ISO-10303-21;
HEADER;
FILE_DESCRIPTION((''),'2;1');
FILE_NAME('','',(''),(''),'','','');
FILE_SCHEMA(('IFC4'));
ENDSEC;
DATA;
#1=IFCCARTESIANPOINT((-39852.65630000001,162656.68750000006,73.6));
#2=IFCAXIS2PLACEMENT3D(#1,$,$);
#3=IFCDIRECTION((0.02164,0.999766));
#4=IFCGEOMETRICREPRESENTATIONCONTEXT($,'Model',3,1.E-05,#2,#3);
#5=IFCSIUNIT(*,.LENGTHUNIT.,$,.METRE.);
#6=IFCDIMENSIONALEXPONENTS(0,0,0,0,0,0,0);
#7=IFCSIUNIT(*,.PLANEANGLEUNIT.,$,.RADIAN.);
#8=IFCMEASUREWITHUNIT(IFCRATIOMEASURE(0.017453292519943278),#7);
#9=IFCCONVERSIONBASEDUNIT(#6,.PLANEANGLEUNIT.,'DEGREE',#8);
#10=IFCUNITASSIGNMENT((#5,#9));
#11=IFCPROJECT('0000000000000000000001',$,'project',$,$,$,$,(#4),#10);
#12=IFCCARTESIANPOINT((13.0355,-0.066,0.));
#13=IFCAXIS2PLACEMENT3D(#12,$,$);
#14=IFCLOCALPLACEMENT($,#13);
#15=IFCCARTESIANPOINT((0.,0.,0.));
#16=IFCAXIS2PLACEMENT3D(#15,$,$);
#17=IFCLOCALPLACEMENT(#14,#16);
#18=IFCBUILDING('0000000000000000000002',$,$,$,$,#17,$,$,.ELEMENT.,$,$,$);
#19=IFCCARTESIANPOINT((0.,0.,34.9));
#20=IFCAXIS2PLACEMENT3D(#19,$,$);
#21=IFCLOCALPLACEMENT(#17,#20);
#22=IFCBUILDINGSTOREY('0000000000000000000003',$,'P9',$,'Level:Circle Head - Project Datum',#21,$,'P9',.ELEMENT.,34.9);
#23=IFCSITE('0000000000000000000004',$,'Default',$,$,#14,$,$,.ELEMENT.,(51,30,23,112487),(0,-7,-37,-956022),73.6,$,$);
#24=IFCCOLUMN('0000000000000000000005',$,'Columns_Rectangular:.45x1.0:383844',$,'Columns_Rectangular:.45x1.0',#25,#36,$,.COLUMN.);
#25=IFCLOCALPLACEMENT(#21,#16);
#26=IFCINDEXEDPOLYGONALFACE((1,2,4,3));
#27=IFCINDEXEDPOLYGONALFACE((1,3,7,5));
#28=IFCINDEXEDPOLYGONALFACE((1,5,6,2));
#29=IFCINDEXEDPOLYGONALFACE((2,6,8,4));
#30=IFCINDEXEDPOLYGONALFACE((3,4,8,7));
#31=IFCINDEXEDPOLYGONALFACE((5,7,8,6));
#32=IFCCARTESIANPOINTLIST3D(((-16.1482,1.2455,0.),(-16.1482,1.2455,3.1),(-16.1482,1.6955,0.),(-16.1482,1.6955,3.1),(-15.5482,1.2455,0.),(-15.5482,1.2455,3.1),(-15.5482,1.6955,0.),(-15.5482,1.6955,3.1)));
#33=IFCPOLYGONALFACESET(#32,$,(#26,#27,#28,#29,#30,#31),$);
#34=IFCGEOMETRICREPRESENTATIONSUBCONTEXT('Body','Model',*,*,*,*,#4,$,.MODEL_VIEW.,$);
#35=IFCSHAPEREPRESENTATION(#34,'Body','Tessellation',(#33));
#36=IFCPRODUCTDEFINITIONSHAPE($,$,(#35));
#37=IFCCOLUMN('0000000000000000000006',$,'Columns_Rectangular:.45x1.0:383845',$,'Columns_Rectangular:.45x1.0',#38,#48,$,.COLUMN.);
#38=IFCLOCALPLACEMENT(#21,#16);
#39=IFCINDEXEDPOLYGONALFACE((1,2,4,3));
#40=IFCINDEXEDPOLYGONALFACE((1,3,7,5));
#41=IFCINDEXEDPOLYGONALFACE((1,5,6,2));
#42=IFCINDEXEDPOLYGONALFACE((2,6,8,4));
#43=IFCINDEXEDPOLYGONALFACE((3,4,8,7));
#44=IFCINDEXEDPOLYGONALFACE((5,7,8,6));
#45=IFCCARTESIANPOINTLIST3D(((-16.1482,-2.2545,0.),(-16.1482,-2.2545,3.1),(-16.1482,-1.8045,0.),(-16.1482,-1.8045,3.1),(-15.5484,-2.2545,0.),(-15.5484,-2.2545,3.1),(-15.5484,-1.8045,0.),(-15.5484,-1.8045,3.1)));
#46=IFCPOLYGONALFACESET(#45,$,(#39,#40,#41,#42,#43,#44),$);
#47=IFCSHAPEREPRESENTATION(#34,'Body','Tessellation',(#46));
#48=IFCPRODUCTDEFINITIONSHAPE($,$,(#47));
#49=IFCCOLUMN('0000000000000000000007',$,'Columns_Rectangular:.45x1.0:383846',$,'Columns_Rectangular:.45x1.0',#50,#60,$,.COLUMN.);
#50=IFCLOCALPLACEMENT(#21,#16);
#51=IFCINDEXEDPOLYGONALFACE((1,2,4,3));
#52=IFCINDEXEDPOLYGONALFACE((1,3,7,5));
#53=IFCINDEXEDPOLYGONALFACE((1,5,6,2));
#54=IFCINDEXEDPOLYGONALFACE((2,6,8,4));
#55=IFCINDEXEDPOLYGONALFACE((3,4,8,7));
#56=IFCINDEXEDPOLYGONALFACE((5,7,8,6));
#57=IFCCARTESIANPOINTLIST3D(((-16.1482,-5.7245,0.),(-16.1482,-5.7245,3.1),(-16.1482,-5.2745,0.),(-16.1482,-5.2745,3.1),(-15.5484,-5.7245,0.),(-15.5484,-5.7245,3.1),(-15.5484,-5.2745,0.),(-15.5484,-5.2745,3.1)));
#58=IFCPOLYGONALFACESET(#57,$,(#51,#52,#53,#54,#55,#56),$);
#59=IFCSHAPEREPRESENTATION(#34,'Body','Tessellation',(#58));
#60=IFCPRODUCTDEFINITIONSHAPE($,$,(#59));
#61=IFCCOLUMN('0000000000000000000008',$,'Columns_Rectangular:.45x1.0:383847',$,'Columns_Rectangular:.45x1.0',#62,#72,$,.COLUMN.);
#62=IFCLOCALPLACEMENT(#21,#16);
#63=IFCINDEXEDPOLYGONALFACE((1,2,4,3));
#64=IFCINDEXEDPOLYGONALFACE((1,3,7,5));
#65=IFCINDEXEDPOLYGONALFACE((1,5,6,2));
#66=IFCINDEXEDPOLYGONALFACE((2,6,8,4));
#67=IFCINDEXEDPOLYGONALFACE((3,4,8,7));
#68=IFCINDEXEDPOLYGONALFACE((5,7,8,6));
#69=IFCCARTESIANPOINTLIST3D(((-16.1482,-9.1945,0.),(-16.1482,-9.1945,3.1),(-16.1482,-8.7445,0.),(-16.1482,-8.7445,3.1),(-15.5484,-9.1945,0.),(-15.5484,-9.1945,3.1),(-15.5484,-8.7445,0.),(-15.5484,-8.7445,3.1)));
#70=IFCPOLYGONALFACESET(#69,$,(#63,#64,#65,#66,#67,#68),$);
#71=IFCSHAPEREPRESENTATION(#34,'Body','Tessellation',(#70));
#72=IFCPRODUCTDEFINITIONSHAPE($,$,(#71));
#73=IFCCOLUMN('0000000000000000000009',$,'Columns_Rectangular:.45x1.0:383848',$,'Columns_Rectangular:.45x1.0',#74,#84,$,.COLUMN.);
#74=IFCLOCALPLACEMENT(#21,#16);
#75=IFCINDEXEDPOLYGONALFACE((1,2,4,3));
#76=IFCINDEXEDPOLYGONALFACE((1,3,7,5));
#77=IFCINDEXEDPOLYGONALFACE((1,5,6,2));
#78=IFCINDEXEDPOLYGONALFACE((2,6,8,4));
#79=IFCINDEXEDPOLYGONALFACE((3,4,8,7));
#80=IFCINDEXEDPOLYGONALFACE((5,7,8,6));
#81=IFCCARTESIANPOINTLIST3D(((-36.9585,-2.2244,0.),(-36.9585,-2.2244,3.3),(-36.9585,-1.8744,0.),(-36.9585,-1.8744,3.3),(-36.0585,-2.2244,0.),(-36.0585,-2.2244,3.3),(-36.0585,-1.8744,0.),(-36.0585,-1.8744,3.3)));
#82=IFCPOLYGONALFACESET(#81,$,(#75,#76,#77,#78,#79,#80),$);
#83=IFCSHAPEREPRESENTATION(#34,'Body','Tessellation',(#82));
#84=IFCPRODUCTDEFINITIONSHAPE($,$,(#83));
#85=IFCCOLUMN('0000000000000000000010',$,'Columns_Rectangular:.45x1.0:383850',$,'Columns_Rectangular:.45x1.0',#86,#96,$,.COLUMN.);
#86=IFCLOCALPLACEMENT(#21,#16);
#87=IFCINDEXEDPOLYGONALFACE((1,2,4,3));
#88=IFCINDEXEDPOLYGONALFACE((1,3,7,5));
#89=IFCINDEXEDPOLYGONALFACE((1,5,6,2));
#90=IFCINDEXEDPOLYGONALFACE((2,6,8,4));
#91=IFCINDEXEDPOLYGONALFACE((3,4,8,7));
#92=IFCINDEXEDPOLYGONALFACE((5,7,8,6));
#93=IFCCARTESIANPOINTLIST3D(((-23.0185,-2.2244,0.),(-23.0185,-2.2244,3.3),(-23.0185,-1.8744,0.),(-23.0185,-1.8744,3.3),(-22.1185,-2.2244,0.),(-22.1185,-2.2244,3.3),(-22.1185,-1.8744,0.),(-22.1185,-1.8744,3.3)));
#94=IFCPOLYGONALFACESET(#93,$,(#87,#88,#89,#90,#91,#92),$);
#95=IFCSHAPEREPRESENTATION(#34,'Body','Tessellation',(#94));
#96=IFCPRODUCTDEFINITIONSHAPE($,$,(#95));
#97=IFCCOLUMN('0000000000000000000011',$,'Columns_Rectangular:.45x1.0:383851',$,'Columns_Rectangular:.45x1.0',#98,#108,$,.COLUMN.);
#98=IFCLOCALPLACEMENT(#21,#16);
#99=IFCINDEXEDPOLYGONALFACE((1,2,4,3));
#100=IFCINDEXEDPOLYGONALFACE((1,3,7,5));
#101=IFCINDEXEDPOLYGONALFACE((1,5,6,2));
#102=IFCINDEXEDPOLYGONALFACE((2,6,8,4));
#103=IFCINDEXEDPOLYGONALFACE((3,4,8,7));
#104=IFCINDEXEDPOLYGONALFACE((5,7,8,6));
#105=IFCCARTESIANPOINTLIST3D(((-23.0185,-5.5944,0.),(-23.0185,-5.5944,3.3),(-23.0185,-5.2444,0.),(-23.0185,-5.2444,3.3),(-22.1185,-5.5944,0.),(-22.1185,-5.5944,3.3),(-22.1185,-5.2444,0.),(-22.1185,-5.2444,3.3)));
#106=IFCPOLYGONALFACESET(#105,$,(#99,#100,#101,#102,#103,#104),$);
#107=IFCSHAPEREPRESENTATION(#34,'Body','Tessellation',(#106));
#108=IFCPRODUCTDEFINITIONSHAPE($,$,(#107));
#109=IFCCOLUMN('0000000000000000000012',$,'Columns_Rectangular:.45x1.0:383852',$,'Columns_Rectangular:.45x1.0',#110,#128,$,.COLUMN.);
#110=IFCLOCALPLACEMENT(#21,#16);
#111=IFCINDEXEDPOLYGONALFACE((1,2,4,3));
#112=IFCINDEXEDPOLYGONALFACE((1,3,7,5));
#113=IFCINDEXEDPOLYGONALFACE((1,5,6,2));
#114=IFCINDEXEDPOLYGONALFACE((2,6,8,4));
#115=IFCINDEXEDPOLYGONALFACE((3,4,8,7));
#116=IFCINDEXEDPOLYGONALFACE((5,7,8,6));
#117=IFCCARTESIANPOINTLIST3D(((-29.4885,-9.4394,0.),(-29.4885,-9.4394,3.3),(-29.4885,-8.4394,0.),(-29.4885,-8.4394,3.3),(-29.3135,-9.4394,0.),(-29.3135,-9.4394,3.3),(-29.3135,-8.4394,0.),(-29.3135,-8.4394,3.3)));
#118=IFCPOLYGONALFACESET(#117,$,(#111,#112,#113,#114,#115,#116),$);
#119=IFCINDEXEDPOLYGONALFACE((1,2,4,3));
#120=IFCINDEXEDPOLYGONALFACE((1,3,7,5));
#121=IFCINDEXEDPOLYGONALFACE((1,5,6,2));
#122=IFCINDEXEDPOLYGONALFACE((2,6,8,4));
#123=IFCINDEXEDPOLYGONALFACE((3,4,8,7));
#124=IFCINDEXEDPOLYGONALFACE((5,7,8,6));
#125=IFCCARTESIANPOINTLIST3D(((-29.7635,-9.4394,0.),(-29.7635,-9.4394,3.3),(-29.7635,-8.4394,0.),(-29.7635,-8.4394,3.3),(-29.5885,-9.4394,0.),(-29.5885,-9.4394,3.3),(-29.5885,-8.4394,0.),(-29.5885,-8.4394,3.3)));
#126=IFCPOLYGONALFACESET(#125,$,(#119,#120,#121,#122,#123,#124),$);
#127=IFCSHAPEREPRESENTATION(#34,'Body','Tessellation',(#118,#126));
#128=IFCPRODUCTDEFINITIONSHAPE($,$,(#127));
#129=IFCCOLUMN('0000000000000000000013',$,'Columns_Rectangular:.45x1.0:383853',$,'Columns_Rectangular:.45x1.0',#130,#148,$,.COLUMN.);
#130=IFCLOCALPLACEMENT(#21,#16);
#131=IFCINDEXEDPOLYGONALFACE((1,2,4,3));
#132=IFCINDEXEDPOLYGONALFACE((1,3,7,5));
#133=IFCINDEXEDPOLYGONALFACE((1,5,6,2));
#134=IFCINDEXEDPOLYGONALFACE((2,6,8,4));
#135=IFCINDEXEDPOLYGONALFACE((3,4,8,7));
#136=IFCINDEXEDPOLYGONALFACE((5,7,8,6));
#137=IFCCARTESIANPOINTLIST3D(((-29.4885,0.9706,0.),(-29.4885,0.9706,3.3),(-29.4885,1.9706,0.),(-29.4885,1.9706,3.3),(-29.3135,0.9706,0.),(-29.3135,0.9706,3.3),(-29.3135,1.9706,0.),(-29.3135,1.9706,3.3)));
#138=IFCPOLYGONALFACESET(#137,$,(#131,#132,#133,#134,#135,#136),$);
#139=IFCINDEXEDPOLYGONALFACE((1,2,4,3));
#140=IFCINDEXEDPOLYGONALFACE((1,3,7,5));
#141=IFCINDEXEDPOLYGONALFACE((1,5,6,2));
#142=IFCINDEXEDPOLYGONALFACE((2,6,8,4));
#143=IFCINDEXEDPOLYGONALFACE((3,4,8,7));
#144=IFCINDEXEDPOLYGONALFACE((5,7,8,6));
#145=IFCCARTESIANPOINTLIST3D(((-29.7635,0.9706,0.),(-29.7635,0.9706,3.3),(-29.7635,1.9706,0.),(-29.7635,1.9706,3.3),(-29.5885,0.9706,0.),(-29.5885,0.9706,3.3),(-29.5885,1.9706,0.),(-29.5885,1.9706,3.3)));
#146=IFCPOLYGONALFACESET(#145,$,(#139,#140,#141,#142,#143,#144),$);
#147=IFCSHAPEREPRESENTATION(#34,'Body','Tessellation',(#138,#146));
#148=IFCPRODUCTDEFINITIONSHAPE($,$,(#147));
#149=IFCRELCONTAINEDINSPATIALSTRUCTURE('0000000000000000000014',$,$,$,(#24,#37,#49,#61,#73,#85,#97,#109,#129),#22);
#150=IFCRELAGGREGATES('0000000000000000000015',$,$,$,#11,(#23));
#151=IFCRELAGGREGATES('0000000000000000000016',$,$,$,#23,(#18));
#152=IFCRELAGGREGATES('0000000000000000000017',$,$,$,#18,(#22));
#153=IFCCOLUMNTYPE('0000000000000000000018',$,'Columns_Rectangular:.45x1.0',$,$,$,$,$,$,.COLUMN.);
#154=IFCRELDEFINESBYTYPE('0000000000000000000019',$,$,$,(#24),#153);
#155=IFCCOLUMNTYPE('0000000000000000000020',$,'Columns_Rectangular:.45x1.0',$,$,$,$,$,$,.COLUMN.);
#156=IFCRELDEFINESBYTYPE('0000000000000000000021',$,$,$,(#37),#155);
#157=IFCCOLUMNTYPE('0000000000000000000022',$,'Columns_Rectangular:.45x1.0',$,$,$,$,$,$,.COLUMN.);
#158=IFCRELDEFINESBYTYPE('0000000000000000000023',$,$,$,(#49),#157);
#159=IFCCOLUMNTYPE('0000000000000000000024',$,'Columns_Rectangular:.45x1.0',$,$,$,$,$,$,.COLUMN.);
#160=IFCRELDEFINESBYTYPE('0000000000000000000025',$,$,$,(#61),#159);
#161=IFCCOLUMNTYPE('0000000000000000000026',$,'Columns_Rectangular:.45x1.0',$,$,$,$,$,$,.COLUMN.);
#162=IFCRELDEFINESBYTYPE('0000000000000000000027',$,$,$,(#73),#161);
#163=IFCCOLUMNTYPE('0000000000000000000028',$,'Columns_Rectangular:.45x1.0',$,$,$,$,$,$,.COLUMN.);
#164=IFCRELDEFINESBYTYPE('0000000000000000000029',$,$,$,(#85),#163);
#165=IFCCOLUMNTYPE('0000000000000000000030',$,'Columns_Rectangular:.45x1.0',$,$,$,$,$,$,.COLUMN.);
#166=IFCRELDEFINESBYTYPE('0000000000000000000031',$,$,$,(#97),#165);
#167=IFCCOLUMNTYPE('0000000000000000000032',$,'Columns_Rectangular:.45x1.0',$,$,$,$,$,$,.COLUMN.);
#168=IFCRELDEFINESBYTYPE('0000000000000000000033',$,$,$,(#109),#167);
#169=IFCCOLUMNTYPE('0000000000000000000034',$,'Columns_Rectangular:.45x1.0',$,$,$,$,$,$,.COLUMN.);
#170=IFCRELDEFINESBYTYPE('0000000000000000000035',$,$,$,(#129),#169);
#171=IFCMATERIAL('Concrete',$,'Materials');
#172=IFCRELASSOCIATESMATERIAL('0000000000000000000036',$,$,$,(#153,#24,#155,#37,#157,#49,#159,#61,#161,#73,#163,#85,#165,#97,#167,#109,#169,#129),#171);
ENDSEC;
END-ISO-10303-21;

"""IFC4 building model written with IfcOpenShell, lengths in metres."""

from ifc_helpers import new_model, entity, si_unit, converted_unit, direction, frame, origin, place, context, subcontext, project, spatial, indexed_curve, outline, extrude, source, transform, mapped, material, type_object, type_shapes, element, save


model = new_model("IFC4")

# Units and contexts
model_context = context("Model", 3, precision=1e-05, world=frame((-39852.65630000001, 162656.68750000006, 73.6)), true_north=direction((0.02164, 0.999766)))
body_context = subcontext(model_context, "Body", "Model", "MODEL_VIEW")
ifc_project = project(units=[si_unit("LENGTHUNIT", "METRE"), converted_unit("PLANEANGLEUNIT", "DEGREE", entity("IfcRatioMeasure", 0.017453292519943278), si_unit("PLANEANGLEUNIT", "RADIAN"), dimensions=[0, 0, 0, 0, 0, 0, 0])], contexts=[model_context])

# Site, building, storey
site_placement = place(None, frame((13.0355, -0.066, 0.0)))
site = spatial("IfcSite", under=ifc_project, at=site_placement, Name="Default", CompositionType="ELEMENT", RefLatitude=(51, 30, 23, 112487), RefLongitude=(0, -7, -37, -956022), RefElevation=73.6)
building_placement = place(site_placement, origin())
building = spatial("IfcBuilding", under=site, at=building_placement, CompositionType="ELEMENT")
storey_placement = place(building_placement, frame((0.0, 0.0, 34.9)))
storey = spatial("IfcBuildingStorey", under=building, at=storey_placement, Name="P9", ObjectType="Level:Circle Head - Project Datum", LongName="P9", CompositionType="ELEMENT", Elevation=34.9)

# Columns
ifc_material = material(Name="Concrete", Category="Materials")
column_type_1 = type_object("IfcColumnType", Name="Columns_Rectangular:.45x1.0", PredefinedType="COLUMN", material=ifc_material)
shared_shape_1 = source(origin(), body_context, "Body", "SweptSolid", [
    extrude(outline(indexed_curve([(-0.225, -0.3), (0.225, -0.3), (0.225, 0.3), (-0.225, 0.3), (-0.225, -0.3)], self_intersect=False)), frame((-15.8482, 1.4705, 34.9), z_axis=(0.0, 0.0, 1.0), x_axis=(0.0, -1.0, 0.0)), (0.0, 0.0, 1.0), 3.1),
])
type_shapes(column_type_1, [shared_shape_1])
column_1_placement = place(storey_placement, frame((0.0, 0.0, -34.9)))
element("IfcColumn", 1, at=column_1_placement, inside=storey, type_object=column_type_1, material=ifc_material, Name="Columns_Rectangular:.45x1.0:383844", ObjectType="Columns_Rectangular:.45x1.0", PredefinedType="COLUMN", context=body_context, shape_type="MappedRepresentation", body=[
    mapped(shared_shape_1, transform((0.0, 0.0, 0.0), scale=1.0)),
])
column_type_2 = type_object("IfcColumnType", Name="Columns_Rectangular:.45x1.0", PredefinedType="COLUMN", material=ifc_material)
shared_shape_2 = source(origin(), body_context, "Body", "SweptSolid", [
    extrude(outline(indexed_curve([(-0.225, -0.2999), (0.225, -0.2999), (0.225, 0.2999), (-0.225, 0.2999), (-0.225, -0.2999)], self_intersect=False)), frame((-15.8483, -2.0295, 34.9), z_axis=(0.0, 0.0, 1.0), x_axis=(0.0, -1.0, 0.0)), (0.0, 0.0, 1.0), 3.1),
])
type_shapes(column_type_2, [shared_shape_2])
column_2_placement = place(storey_placement, frame((0.0, 0.0, -34.9)))
element("IfcColumn", 2, at=column_2_placement, inside=storey, type_object=column_type_2, material=ifc_material, Name="Columns_Rectangular:.45x1.0:383845", ObjectType="Columns_Rectangular:.45x1.0", PredefinedType="COLUMN", context=body_context, shape_type="MappedRepresentation", body=[
    mapped(shared_shape_2, transform((0.0, 0.0, 0.0), scale=1.0)),
])
column_type_3 = type_object("IfcColumnType", Name="Columns_Rectangular:.45x1.0", PredefinedType="COLUMN", material=ifc_material)
shared_shape_3 = source(origin(), body_context, "Body", "SweptSolid", [
    extrude(outline(indexed_curve([(-0.225, -0.2999), (0.225, -0.2999), (0.225, 0.2999), (-0.225, 0.2999), (-0.225, -0.2999)], self_intersect=False)), frame((-15.8483, -5.4995, 34.9), z_axis=(0.0, 0.0, 1.0), x_axis=(0.0, -1.0, 0.0)), (0.0, 0.0, 1.0), 3.1),
])
type_shapes(column_type_3, [shared_shape_3])
column_3_placement = place(storey_placement, frame((0.0, 0.0, -34.9)))
element("IfcColumn", 3, at=column_3_placement, inside=storey, type_object=column_type_3, material=ifc_material, Name="Columns_Rectangular:.45x1.0:383846", ObjectType="Columns_Rectangular:.45x1.0", PredefinedType="COLUMN", context=body_context, shape_type="MappedRepresentation", body=[
    mapped(shared_shape_3, transform((0.0, 0.0, 0.0), scale=1.0)),
])
column_type_4 = type_object("IfcColumnType", Name="Columns_Rectangular:.45x1.0", PredefinedType="COLUMN", material=ifc_material)
shared_shape_4 = source(origin(), body_context, "Body", "SweptSolid", [
    extrude(outline(indexed_curve([(-0.225, -0.2999), (0.225, -0.2999), (0.225, 0.2999), (-0.225, 0.2999), (-0.225, -0.2999)], self_intersect=False)), frame((-15.8483, -8.9695, 34.9), z_axis=(0.0, 0.0, 1.0), x_axis=(0.0, -1.0, 0.0)), (0.0, 0.0, 1.0), 3.1),
])
type_shapes(column_type_4, [shared_shape_4])
column_4_placement = place(storey_placement, frame((0.0, 0.0, -34.9)))
element("IfcColumn", 4, at=column_4_placement, inside=storey, type_object=column_type_4, material=ifc_material, Name="Columns_Rectangular:.45x1.0:383847", ObjectType="Columns_Rectangular:.45x1.0", PredefinedType="COLUMN", context=body_context, shape_type="MappedRepresentation", body=[
    mapped(shared_shape_4, transform((0.0, 0.0, 0.0), scale=1.0)),
])
column_type_5 = type_object("IfcColumnType", Name="Columns_Rectangular:.45x1.0", PredefinedType="COLUMN", material=ifc_material)
shared_shape_5 = source(origin(), body_context, "Body", "SweptSolid", [
    extrude(outline(indexed_curve([(-0.175, -0.45), (0.175, -0.45), (0.175, 0.45), (-0.175, 0.45), (-0.175, -0.45)], self_intersect=False)), frame((-36.5085, -2.0494, 34.9), z_axis=(0.0, 0.0, 1.0), x_axis=(0.0, -1.0, 0.0)), (0.0, 0.0, 1.0), 3.3),
])
type_shapes(column_type_5, [shared_shape_5])
column_5_placement = place(storey_placement, frame((0.0, 0.0, -34.9)))
element("IfcColumn", 5, at=column_5_placement, inside=storey, type_object=column_type_5, material=ifc_material, Name="Columns_Rectangular:.45x1.0:383848", ObjectType="Columns_Rectangular:.45x1.0", PredefinedType="COLUMN", context=body_context, shape_type="MappedRepresentation", body=[
    mapped(shared_shape_5, transform((0.0, 0.0, 0.0), scale=1.0)),
])
column_type_6 = type_object("IfcColumnType", Name="Columns_Rectangular:.45x1.0", PredefinedType="COLUMN", material=ifc_material)
shared_shape_6 = source(origin(), body_context, "Body", "SweptSolid", [
    extrude(outline(indexed_curve([(-0.175, -0.45), (0.175, -0.45), (0.175, 0.45), (-0.175, 0.45), (-0.175, -0.45)], self_intersect=False)), frame((-22.5685, -2.0494, 34.9), z_axis=(0.0, 0.0, 1.0), x_axis=(0.0, -1.0, 0.0)), (0.0, 0.0, 1.0), 3.3),
])
type_shapes(column_type_6, [shared_shape_6])
column_6_placement = place(storey_placement, frame((0.0, 0.0, -34.9)))
element("IfcColumn", 6, at=column_6_placement, inside=storey, type_object=column_type_6, material=ifc_material, Name="Columns_Rectangular:.45x1.0:383850", ObjectType="Columns_Rectangular:.45x1.0", PredefinedType="COLUMN", context=body_context, shape_type="MappedRepresentation", body=[
    mapped(shared_shape_6, transform((0.0, 0.0, 0.0), scale=1.0)),
])
column_type_7 = type_object("IfcColumnType", Name="Columns_Rectangular:.45x1.0", PredefinedType="COLUMN", material=ifc_material)
shared_shape_7 = source(origin(), body_context, "Body", "SweptSolid", [
    extrude(outline(indexed_curve([(-0.175, -0.45), (0.175, -0.45), (0.175, 0.45), (-0.175, 0.45), (-0.175, -0.45)], self_intersect=False)), frame((-22.5685, -5.4194, 34.9), z_axis=(0.0, 0.0, 1.0), x_axis=(0.0, -1.0, 0.0)), (0.0, 0.0, 1.0), 3.3),
])
type_shapes(column_type_7, [shared_shape_7])
column_7_placement = place(storey_placement, frame((0.0, 0.0, -34.9)))
element("IfcColumn", 7, at=column_7_placement, inside=storey, type_object=column_type_7, material=ifc_material, Name="Columns_Rectangular:.45x1.0:383851", ObjectType="Columns_Rectangular:.45x1.0", PredefinedType="COLUMN", context=body_context, shape_type="MappedRepresentation", body=[
    mapped(shared_shape_7, transform((0.0, 0.0, 0.0), scale=1.0)),
])
column_type_8 = type_object("IfcColumnType", Name="Columns_Rectangular:.45x1.0", PredefinedType="COLUMN", material=ifc_material)
shared_shape_8 = source(origin(), body_context, "Body", "SweptSolid", [
    extrude(outline(indexed_curve([(-0.5, -0.0875), (0.5, -0.0875), (0.5, 0.0875), (-0.5, 0.0875), (-0.5, -0.0875)], self_intersect=False)), frame((-29.401, -8.9394, 34.9), z_axis=(0.0, 0.0, 1.0), x_axis=(0.0, -1.0, 0.0)), (0.0, 0.0, 1.0), 3.3),
    extrude(outline(indexed_curve([(-0.5, -0.0875), (0.5, -0.0875), (0.5, 0.0875), (-0.5, 0.0875), (-0.5, -0.0875)], self_intersect=False)), frame((-29.676, -8.9394, 34.9), z_axis=(0.0, 0.0, 1.0), x_axis=(0.0, -1.0, 0.0)), (0.0, 0.0, 1.0), 3.3),
])
type_shapes(column_type_8, [shared_shape_8])
column_8_placement = place(storey_placement, frame((0.0, 0.0, -34.9)))
element("IfcColumn", 8, at=column_8_placement, inside=storey, type_object=column_type_8, material=ifc_material, Name="Columns_Rectangular:.45x1.0:383852", ObjectType="Columns_Rectangular:.45x1.0", PredefinedType="COLUMN", context=body_context, shape_type="MappedRepresentation", body=[
    mapped(shared_shape_8, transform((0.0, 0.0, 0.0), scale=1.0)),
])
column_type_9 = type_object("IfcColumnType", Name="Columns_Rectangular:.45x1.0", PredefinedType="COLUMN", material=ifc_material)
shared_shape_9 = source(origin(), body_context, "Body", "SweptSolid", [
    extrude(outline(indexed_curve([(-0.5, -0.0875), (0.5, -0.0875), (0.5, 0.0875), (-0.5, 0.0875), (-0.5, -0.0875)], self_intersect=False)), frame((-29.401, 1.4706, 34.9), z_axis=(0.0, 0.0, 1.0), x_axis=(0.0, -1.0, 0.0)), (0.0, 0.0, 1.0), 3.3),
    extrude(outline(indexed_curve([(-0.5, -0.0875), (0.5, -0.0875), (0.5, 0.0875), (-0.5, 0.0875), (-0.5, -0.0875)], self_intersect=False)), frame((-29.676, 1.4706, 34.9), z_axis=(0.0, 0.0, 1.0), x_axis=(0.0, -1.0, 0.0)), (0.0, 0.0, 1.0), 3.3),
])
type_shapes(column_type_9, [shared_shape_9])
column_9_placement = place(storey_placement, frame((0.0, 0.0, -34.9)))
element("IfcColumn", 9, at=column_9_placement, inside=storey, type_object=column_type_9, material=ifc_material, Name="Columns_Rectangular:.45x1.0:383853", ObjectType="Columns_Rectangular:.45x1.0", PredefinedType="COLUMN", context=body_context, shape_type="MappedRepresentation", body=[
    mapped(shared_shape_9, transform((0.0, 0.0, 0.0), scale=1.0)),
])

save(model, "model.ifc")
